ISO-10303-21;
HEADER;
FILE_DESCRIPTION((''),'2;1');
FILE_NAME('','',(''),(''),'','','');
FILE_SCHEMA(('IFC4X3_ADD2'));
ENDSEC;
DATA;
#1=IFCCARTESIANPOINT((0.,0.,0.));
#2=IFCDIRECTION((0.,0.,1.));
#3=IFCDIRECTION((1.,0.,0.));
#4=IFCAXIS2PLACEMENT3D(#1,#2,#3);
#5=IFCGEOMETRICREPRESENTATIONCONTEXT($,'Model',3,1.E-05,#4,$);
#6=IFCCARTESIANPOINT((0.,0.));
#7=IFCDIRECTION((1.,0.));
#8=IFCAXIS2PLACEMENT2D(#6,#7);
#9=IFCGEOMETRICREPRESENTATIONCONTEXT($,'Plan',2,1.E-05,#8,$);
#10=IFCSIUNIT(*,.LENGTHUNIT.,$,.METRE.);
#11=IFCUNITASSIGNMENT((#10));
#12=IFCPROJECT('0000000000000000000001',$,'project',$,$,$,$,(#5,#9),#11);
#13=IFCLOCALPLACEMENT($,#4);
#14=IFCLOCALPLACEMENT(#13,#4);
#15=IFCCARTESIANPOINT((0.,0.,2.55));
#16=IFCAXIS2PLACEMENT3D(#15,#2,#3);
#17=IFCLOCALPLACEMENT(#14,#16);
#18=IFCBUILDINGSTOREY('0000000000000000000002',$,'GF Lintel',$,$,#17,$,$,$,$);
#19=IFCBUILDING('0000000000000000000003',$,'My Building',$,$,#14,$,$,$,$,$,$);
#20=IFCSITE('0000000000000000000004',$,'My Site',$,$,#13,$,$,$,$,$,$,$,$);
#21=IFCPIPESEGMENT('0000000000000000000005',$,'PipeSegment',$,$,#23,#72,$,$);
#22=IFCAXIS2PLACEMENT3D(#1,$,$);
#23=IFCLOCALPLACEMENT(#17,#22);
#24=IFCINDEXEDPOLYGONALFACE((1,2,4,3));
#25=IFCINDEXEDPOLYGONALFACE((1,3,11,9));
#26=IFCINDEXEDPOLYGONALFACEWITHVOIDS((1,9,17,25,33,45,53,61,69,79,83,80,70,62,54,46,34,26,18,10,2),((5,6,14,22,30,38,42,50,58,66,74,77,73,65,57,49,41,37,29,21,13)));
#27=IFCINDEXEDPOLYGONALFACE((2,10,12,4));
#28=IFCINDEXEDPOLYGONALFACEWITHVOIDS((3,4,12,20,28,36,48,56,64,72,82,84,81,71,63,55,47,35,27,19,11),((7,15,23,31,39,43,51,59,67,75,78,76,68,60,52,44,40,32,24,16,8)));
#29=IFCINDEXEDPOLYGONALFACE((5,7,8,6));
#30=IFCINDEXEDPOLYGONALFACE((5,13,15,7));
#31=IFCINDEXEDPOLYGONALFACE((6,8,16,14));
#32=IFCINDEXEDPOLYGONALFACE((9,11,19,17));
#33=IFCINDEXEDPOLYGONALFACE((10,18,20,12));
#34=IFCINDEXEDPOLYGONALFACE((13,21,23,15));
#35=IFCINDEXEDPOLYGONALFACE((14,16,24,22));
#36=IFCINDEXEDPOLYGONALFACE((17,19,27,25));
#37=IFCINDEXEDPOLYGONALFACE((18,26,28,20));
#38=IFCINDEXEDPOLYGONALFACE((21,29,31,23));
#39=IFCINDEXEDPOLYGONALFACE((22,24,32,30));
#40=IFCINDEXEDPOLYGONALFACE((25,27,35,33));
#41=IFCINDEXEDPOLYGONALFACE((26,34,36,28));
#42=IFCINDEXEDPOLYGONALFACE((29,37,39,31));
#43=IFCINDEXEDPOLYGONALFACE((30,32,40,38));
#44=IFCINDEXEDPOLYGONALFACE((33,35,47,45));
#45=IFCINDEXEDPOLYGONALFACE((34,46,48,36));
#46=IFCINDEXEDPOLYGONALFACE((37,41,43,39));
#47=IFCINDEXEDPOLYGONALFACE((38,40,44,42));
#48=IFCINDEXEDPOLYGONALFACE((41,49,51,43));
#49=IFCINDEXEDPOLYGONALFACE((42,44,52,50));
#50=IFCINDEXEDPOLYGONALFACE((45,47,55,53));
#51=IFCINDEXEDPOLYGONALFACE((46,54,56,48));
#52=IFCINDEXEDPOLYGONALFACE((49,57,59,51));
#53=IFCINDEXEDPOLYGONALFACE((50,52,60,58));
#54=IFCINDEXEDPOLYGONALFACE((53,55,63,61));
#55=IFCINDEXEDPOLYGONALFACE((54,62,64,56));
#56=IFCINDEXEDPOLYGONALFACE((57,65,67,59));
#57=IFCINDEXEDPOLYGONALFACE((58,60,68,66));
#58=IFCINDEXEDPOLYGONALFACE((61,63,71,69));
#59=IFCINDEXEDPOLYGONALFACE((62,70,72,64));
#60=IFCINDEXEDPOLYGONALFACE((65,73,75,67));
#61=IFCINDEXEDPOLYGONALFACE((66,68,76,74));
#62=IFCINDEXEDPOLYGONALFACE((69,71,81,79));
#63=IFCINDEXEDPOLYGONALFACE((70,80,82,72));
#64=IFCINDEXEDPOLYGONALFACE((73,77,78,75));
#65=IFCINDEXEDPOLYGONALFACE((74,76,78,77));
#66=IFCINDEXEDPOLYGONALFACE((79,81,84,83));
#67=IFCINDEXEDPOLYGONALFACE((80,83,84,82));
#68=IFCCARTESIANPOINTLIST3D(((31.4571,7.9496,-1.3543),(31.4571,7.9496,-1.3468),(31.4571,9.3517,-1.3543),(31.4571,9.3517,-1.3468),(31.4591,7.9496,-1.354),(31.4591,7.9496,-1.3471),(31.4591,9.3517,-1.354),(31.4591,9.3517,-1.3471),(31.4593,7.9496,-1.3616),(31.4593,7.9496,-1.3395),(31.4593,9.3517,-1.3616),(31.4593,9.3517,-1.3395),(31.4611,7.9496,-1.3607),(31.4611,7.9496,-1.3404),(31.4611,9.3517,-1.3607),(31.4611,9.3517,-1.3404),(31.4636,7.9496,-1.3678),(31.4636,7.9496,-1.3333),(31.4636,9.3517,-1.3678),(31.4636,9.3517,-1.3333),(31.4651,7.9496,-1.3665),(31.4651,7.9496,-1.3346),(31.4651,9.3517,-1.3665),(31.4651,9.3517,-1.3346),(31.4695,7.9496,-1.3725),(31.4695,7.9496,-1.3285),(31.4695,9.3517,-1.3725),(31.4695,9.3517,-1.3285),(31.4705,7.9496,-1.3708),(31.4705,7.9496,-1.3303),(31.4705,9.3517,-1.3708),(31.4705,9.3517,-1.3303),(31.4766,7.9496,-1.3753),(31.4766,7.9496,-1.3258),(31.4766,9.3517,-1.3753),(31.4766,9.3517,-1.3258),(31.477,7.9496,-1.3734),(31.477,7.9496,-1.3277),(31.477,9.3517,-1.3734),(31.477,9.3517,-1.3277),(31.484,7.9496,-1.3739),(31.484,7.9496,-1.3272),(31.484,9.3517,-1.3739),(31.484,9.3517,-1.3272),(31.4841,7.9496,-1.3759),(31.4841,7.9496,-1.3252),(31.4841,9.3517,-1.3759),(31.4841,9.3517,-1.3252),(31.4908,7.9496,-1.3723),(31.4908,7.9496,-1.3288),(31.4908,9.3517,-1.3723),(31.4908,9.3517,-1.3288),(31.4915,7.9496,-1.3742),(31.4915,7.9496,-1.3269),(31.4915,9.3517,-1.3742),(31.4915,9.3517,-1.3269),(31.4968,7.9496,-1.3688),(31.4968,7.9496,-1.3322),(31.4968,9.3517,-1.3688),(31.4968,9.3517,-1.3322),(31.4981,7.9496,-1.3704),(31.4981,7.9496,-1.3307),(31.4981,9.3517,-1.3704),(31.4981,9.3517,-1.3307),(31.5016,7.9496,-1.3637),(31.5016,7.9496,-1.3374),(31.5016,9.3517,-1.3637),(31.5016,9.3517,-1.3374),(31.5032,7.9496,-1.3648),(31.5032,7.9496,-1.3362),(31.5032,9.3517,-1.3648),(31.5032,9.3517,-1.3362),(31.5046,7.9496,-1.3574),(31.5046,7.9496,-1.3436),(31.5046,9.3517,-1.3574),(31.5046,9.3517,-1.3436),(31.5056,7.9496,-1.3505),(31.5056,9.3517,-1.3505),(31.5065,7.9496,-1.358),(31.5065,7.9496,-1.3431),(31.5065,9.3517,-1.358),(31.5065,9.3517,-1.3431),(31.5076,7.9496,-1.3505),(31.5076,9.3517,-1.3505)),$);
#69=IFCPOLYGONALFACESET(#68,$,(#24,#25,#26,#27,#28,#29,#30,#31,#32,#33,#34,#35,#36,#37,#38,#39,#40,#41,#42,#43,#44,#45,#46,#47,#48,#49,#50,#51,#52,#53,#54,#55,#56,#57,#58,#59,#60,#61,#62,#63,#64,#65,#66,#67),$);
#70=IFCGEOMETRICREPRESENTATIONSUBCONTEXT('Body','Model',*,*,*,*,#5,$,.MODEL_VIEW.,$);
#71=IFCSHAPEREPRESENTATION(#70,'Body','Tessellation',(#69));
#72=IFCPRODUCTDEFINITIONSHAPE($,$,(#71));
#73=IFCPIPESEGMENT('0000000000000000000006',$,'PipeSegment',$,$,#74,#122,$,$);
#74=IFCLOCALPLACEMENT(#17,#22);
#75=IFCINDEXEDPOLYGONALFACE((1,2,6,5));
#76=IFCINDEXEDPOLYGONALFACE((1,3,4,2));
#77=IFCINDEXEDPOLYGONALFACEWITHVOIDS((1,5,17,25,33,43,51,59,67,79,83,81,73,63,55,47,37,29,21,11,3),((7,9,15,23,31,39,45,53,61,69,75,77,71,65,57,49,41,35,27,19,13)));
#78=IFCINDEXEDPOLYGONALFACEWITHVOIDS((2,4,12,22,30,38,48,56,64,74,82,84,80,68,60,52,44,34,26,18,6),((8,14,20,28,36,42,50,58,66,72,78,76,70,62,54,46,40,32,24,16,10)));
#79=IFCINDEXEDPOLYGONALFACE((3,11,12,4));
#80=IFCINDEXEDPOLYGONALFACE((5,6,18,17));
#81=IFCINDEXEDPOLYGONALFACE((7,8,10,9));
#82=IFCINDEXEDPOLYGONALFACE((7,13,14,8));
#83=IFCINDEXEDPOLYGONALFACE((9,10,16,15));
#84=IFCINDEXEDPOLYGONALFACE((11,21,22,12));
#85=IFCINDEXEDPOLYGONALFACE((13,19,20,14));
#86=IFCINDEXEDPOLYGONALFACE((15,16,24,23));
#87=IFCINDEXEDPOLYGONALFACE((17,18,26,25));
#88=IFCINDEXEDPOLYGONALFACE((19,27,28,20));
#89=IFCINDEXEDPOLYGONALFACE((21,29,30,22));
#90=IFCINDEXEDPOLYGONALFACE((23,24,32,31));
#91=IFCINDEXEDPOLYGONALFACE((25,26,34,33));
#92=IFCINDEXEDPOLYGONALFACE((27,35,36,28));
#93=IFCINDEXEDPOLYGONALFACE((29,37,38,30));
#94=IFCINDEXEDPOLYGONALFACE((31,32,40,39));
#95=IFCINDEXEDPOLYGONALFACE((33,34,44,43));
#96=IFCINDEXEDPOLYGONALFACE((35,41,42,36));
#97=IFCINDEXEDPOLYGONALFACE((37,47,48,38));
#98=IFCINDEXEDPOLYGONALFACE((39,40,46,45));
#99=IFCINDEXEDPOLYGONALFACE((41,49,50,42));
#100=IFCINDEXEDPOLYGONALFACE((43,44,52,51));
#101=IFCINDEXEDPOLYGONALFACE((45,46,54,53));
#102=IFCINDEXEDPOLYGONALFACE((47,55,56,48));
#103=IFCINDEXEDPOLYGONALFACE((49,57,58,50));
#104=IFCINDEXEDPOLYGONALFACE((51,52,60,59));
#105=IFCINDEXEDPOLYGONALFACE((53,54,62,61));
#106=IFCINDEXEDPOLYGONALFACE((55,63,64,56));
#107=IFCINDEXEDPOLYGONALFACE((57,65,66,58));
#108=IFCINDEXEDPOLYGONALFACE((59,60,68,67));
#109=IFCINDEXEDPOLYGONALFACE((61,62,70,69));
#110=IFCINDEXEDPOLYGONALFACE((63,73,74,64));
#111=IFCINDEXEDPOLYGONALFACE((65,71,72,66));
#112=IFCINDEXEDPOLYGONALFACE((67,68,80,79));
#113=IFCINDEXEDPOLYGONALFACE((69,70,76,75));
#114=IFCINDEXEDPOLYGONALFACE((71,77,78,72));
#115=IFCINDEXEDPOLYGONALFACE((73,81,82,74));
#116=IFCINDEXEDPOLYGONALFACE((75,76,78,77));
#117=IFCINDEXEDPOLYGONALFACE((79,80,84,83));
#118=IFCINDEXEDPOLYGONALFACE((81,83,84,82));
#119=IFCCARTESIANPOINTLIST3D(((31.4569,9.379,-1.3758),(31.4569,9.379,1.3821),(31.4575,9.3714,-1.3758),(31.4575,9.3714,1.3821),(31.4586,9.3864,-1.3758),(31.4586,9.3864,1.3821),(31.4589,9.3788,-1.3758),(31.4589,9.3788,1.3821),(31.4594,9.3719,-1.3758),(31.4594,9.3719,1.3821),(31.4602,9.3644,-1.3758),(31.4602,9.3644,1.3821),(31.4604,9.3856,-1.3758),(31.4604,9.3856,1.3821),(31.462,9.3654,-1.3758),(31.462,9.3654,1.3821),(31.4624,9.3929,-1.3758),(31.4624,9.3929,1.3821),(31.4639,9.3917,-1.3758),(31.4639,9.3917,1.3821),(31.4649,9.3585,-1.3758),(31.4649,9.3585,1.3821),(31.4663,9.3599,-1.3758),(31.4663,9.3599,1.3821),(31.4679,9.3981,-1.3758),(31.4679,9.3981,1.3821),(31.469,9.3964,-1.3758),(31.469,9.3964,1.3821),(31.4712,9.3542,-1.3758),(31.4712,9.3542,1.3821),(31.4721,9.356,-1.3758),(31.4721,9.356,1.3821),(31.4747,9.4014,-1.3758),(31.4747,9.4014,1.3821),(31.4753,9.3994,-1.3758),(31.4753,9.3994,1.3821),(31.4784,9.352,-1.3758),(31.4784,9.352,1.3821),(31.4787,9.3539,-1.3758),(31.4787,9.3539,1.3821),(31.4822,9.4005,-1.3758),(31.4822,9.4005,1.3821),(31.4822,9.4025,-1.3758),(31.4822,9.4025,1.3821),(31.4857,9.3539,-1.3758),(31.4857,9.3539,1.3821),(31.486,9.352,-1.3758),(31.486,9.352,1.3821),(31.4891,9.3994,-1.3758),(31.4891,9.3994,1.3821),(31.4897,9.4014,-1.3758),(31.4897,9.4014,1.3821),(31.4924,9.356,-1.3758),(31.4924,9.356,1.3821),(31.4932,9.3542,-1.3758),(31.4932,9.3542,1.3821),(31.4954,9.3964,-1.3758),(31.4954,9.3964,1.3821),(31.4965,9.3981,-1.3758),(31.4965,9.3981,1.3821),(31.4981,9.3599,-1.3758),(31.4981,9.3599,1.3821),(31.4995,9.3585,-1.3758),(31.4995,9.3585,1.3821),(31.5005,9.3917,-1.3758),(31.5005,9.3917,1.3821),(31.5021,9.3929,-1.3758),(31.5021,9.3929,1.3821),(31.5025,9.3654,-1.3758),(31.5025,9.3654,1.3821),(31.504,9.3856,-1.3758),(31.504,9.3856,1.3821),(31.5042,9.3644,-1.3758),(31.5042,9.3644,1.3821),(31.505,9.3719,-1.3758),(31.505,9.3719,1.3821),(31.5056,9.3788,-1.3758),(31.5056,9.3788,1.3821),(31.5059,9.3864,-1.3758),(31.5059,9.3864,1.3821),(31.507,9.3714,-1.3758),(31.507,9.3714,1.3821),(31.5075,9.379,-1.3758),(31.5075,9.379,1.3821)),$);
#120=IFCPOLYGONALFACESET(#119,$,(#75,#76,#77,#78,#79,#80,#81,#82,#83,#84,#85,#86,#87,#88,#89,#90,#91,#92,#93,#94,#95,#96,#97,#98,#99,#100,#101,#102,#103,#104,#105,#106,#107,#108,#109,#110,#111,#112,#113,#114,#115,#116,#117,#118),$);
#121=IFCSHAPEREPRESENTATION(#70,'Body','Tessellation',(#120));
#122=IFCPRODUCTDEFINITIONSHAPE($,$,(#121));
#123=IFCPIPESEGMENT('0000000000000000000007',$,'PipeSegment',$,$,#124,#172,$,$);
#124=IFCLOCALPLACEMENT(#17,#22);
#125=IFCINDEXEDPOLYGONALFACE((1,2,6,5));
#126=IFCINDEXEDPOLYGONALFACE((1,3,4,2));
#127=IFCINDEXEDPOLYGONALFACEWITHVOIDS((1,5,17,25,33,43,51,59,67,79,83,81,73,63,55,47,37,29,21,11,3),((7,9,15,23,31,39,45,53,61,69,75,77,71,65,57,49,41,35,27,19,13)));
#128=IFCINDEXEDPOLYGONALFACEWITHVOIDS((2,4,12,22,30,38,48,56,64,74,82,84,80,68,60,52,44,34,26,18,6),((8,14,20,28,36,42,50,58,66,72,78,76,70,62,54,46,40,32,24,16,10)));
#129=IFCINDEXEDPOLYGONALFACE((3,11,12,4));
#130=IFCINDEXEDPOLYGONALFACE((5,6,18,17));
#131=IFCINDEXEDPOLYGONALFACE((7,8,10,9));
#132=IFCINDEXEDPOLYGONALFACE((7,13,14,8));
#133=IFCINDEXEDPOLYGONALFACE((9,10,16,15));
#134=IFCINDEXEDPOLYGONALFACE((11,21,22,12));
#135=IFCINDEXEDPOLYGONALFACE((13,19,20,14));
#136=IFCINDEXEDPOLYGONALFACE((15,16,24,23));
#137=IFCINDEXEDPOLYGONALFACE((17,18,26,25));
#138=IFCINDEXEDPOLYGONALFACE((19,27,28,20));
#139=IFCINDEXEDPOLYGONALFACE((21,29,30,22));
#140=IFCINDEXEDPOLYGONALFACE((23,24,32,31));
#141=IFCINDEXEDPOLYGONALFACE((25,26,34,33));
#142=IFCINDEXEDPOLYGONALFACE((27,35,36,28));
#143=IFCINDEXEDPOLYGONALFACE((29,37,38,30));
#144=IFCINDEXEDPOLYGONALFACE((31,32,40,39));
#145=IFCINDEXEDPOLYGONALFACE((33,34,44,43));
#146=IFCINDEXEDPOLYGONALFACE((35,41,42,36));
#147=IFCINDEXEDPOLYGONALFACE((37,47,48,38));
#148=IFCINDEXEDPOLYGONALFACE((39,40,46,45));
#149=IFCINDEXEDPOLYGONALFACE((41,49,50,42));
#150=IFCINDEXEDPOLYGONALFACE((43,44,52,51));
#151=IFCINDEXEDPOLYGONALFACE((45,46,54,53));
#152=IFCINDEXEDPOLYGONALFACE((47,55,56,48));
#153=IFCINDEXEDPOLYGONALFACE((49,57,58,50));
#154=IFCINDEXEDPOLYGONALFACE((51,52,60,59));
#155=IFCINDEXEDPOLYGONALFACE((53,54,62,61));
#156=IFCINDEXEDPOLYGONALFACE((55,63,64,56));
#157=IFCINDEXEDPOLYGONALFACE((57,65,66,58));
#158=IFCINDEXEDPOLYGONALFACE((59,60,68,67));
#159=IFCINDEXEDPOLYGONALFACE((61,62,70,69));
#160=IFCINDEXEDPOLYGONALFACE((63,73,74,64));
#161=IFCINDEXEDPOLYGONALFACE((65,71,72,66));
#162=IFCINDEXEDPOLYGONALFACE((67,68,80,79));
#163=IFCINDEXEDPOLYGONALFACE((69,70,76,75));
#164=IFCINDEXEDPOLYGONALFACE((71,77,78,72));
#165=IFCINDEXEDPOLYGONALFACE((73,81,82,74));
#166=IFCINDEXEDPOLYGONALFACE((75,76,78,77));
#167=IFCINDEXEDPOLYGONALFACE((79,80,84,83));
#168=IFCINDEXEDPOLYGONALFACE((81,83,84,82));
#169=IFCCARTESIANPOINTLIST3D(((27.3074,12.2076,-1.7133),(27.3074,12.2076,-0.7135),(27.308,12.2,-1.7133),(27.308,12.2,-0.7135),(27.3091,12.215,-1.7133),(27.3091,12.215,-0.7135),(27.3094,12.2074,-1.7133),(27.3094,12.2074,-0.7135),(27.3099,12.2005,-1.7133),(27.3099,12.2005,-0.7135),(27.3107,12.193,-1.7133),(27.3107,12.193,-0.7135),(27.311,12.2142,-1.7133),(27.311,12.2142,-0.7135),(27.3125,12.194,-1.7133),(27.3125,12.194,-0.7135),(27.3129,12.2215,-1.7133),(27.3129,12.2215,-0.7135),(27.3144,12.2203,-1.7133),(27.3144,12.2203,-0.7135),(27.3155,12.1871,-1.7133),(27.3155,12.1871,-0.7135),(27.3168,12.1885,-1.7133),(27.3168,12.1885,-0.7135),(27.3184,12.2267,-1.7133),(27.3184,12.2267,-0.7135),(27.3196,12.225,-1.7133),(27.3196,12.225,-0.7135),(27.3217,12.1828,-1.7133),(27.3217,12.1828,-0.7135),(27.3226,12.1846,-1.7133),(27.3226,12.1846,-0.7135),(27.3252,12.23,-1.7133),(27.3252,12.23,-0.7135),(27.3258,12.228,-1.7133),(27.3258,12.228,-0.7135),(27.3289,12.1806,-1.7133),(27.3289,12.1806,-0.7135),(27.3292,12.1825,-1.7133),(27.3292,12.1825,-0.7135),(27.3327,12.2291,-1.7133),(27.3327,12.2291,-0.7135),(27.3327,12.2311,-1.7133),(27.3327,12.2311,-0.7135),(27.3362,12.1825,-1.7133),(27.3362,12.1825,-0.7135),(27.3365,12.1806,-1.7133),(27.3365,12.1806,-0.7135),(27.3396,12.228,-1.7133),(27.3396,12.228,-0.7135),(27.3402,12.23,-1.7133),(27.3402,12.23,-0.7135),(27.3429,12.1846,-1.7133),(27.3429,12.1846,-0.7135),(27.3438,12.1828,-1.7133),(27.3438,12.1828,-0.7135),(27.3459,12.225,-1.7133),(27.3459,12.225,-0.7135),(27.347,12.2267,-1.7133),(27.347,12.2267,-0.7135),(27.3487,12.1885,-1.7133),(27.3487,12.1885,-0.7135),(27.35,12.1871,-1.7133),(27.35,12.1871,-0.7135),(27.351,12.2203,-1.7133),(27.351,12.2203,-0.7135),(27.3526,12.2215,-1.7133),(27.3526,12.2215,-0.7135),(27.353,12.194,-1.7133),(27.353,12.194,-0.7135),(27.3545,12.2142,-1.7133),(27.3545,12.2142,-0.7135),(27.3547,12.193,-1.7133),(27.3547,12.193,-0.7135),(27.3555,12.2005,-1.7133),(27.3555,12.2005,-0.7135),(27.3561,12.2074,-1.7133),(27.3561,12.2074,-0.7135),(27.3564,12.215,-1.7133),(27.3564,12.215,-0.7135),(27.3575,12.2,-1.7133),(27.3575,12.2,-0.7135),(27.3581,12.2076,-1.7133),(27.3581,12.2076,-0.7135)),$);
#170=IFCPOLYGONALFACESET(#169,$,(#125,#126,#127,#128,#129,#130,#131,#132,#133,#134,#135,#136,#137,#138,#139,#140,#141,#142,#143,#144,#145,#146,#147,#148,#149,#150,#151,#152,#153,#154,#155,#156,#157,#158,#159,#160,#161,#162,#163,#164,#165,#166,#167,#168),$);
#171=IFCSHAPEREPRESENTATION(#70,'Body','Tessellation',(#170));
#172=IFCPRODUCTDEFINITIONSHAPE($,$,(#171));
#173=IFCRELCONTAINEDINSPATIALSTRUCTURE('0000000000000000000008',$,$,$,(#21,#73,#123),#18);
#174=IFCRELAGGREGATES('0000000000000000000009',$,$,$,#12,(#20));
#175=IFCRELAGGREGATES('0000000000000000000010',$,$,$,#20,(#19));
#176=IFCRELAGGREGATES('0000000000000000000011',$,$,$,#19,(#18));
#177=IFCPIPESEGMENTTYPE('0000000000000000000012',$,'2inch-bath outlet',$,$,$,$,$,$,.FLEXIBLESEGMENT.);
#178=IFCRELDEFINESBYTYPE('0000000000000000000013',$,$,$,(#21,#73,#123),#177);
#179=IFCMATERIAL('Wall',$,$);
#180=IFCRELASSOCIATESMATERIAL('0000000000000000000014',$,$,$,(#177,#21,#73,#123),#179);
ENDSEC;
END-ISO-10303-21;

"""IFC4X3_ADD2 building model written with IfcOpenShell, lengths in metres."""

from ifc_helpers import new_model, si_unit, frame, origin_with_axes, origin_2d_with_axis, place, context, subcontext, project, spatial, hollow_circle, extrude, material, material_profile, profile_set, profile_usage, type_object, element, save


model = new_model("IFC4X3_ADD2")

# Units and contexts
model_context = context("Model", 3, precision=1e-05, world=origin_with_axes())
plan_context = context("Plan", 2, precision=1e-05, world=origin_2d_with_axis())
body_context = subcontext(model_context, "Body", "Model", "MODEL_VIEW")
ifc_project = project(units=[si_unit("LENGTHUNIT", "METRE")], contexts=[model_context, plan_context])

# Site, building, storey
site_placement = place(None, origin_with_axes())
site = spatial("IfcSite", under=ifc_project, at=site_placement, Name="My Site")
building_placement = place(site_placement, origin_with_axes())
building = spatial("IfcBuilding", under=site, at=building_placement, Name="My Building")
storey_placement = place(building_placement, frame((0.0, 0.0, 2.55), z_axis=(0.0, 0.0, 1.0), x_axis=(1.0, 0.0, 0.0)))
storey = spatial("IfcBuildingStorey", under=building, at=storey_placement, Name="GF Lintel")

# Shared definitions
ifc_material_1 = material(Name="Wall")

# Pipe segments
ifc_material_profile_1 = material_profile(ifc_material_1, hollow_circle(Radius=0.0254, WallThickness=0.002))
ifc_profile_set_1 = profile_set([ifc_material_profile_1], Name="graywater")
ifc_profile_usage_1 = profile_usage(ifc_profile_set_1, cardinal=5)
pipe_segment_type_1 = type_object("IfcPipeSegmentType", Name="2inch-bath outlet", PredefinedType="FLEXIBLESEGMENT", material=ifc_profile_set_1)
pipe_segment_1_placement = place(storey_placement, frame((31.4822, 9.3517, -1.3505), z_axis=(0.0, -1.0, 0.0), x_axis=(1.0, 0.0, 0.0)))
element("IfcPipeSegment", 1, at=pipe_segment_1_placement, inside=storey, type_object=pipe_segment_type_1, material=ifc_profile_usage_1, Name="PipeSegment", context=body_context, shape_type="SweptSolid", body=[
    extrude(hollow_circle(Radius=0.0254, WallThickness=0.002), origin_with_axes(), (0.0, 0.0, 1.0), 1.4021),
])
ifc_profile_usage_2 = profile_usage(ifc_profile_set_1, cardinal=5)
pipe_segment_2_placement = place(storey_placement, frame((31.4822, 9.3771, -1.3758), z_axis=(0.0, 0.0, 1.0), x_axis=(0.0, 1.0, 0.0)))
element("IfcPipeSegment", 2, at=pipe_segment_2_placement, inside=storey, type_object=pipe_segment_type_1, material=ifc_profile_usage_2, Name="PipeSegment", context=body_context, shape_type="SweptSolid", body=[
    extrude(hollow_circle(Radius=0.0254, WallThickness=0.002), origin_with_axes(), (0.0, 0.0, 1.0), 2.7578),
])
ifc_profile_usage_3 = profile_usage(ifc_profile_set_1, cardinal=5)
pipe_segment_3_placement = place(storey_placement, frame((27.3327, 12.2057, -1.7133), z_axis=(0.0, 0.0, 1.0), x_axis=(0.0, 1.0, 0.0)))
element("IfcPipeSegment", 3, at=pipe_segment_3_placement, inside=storey, type_object=pipe_segment_type_1, material=ifc_profile_usage_3, Name="PipeSegment", context=body_context, shape_type="SweptSolid", body=[
    extrude(hollow_circle(Radius=0.0254, WallThickness=0.002), origin_with_axes(), (0.0, 0.0, 1.0), 0.9998),
])

save(model, "model.ifc")
